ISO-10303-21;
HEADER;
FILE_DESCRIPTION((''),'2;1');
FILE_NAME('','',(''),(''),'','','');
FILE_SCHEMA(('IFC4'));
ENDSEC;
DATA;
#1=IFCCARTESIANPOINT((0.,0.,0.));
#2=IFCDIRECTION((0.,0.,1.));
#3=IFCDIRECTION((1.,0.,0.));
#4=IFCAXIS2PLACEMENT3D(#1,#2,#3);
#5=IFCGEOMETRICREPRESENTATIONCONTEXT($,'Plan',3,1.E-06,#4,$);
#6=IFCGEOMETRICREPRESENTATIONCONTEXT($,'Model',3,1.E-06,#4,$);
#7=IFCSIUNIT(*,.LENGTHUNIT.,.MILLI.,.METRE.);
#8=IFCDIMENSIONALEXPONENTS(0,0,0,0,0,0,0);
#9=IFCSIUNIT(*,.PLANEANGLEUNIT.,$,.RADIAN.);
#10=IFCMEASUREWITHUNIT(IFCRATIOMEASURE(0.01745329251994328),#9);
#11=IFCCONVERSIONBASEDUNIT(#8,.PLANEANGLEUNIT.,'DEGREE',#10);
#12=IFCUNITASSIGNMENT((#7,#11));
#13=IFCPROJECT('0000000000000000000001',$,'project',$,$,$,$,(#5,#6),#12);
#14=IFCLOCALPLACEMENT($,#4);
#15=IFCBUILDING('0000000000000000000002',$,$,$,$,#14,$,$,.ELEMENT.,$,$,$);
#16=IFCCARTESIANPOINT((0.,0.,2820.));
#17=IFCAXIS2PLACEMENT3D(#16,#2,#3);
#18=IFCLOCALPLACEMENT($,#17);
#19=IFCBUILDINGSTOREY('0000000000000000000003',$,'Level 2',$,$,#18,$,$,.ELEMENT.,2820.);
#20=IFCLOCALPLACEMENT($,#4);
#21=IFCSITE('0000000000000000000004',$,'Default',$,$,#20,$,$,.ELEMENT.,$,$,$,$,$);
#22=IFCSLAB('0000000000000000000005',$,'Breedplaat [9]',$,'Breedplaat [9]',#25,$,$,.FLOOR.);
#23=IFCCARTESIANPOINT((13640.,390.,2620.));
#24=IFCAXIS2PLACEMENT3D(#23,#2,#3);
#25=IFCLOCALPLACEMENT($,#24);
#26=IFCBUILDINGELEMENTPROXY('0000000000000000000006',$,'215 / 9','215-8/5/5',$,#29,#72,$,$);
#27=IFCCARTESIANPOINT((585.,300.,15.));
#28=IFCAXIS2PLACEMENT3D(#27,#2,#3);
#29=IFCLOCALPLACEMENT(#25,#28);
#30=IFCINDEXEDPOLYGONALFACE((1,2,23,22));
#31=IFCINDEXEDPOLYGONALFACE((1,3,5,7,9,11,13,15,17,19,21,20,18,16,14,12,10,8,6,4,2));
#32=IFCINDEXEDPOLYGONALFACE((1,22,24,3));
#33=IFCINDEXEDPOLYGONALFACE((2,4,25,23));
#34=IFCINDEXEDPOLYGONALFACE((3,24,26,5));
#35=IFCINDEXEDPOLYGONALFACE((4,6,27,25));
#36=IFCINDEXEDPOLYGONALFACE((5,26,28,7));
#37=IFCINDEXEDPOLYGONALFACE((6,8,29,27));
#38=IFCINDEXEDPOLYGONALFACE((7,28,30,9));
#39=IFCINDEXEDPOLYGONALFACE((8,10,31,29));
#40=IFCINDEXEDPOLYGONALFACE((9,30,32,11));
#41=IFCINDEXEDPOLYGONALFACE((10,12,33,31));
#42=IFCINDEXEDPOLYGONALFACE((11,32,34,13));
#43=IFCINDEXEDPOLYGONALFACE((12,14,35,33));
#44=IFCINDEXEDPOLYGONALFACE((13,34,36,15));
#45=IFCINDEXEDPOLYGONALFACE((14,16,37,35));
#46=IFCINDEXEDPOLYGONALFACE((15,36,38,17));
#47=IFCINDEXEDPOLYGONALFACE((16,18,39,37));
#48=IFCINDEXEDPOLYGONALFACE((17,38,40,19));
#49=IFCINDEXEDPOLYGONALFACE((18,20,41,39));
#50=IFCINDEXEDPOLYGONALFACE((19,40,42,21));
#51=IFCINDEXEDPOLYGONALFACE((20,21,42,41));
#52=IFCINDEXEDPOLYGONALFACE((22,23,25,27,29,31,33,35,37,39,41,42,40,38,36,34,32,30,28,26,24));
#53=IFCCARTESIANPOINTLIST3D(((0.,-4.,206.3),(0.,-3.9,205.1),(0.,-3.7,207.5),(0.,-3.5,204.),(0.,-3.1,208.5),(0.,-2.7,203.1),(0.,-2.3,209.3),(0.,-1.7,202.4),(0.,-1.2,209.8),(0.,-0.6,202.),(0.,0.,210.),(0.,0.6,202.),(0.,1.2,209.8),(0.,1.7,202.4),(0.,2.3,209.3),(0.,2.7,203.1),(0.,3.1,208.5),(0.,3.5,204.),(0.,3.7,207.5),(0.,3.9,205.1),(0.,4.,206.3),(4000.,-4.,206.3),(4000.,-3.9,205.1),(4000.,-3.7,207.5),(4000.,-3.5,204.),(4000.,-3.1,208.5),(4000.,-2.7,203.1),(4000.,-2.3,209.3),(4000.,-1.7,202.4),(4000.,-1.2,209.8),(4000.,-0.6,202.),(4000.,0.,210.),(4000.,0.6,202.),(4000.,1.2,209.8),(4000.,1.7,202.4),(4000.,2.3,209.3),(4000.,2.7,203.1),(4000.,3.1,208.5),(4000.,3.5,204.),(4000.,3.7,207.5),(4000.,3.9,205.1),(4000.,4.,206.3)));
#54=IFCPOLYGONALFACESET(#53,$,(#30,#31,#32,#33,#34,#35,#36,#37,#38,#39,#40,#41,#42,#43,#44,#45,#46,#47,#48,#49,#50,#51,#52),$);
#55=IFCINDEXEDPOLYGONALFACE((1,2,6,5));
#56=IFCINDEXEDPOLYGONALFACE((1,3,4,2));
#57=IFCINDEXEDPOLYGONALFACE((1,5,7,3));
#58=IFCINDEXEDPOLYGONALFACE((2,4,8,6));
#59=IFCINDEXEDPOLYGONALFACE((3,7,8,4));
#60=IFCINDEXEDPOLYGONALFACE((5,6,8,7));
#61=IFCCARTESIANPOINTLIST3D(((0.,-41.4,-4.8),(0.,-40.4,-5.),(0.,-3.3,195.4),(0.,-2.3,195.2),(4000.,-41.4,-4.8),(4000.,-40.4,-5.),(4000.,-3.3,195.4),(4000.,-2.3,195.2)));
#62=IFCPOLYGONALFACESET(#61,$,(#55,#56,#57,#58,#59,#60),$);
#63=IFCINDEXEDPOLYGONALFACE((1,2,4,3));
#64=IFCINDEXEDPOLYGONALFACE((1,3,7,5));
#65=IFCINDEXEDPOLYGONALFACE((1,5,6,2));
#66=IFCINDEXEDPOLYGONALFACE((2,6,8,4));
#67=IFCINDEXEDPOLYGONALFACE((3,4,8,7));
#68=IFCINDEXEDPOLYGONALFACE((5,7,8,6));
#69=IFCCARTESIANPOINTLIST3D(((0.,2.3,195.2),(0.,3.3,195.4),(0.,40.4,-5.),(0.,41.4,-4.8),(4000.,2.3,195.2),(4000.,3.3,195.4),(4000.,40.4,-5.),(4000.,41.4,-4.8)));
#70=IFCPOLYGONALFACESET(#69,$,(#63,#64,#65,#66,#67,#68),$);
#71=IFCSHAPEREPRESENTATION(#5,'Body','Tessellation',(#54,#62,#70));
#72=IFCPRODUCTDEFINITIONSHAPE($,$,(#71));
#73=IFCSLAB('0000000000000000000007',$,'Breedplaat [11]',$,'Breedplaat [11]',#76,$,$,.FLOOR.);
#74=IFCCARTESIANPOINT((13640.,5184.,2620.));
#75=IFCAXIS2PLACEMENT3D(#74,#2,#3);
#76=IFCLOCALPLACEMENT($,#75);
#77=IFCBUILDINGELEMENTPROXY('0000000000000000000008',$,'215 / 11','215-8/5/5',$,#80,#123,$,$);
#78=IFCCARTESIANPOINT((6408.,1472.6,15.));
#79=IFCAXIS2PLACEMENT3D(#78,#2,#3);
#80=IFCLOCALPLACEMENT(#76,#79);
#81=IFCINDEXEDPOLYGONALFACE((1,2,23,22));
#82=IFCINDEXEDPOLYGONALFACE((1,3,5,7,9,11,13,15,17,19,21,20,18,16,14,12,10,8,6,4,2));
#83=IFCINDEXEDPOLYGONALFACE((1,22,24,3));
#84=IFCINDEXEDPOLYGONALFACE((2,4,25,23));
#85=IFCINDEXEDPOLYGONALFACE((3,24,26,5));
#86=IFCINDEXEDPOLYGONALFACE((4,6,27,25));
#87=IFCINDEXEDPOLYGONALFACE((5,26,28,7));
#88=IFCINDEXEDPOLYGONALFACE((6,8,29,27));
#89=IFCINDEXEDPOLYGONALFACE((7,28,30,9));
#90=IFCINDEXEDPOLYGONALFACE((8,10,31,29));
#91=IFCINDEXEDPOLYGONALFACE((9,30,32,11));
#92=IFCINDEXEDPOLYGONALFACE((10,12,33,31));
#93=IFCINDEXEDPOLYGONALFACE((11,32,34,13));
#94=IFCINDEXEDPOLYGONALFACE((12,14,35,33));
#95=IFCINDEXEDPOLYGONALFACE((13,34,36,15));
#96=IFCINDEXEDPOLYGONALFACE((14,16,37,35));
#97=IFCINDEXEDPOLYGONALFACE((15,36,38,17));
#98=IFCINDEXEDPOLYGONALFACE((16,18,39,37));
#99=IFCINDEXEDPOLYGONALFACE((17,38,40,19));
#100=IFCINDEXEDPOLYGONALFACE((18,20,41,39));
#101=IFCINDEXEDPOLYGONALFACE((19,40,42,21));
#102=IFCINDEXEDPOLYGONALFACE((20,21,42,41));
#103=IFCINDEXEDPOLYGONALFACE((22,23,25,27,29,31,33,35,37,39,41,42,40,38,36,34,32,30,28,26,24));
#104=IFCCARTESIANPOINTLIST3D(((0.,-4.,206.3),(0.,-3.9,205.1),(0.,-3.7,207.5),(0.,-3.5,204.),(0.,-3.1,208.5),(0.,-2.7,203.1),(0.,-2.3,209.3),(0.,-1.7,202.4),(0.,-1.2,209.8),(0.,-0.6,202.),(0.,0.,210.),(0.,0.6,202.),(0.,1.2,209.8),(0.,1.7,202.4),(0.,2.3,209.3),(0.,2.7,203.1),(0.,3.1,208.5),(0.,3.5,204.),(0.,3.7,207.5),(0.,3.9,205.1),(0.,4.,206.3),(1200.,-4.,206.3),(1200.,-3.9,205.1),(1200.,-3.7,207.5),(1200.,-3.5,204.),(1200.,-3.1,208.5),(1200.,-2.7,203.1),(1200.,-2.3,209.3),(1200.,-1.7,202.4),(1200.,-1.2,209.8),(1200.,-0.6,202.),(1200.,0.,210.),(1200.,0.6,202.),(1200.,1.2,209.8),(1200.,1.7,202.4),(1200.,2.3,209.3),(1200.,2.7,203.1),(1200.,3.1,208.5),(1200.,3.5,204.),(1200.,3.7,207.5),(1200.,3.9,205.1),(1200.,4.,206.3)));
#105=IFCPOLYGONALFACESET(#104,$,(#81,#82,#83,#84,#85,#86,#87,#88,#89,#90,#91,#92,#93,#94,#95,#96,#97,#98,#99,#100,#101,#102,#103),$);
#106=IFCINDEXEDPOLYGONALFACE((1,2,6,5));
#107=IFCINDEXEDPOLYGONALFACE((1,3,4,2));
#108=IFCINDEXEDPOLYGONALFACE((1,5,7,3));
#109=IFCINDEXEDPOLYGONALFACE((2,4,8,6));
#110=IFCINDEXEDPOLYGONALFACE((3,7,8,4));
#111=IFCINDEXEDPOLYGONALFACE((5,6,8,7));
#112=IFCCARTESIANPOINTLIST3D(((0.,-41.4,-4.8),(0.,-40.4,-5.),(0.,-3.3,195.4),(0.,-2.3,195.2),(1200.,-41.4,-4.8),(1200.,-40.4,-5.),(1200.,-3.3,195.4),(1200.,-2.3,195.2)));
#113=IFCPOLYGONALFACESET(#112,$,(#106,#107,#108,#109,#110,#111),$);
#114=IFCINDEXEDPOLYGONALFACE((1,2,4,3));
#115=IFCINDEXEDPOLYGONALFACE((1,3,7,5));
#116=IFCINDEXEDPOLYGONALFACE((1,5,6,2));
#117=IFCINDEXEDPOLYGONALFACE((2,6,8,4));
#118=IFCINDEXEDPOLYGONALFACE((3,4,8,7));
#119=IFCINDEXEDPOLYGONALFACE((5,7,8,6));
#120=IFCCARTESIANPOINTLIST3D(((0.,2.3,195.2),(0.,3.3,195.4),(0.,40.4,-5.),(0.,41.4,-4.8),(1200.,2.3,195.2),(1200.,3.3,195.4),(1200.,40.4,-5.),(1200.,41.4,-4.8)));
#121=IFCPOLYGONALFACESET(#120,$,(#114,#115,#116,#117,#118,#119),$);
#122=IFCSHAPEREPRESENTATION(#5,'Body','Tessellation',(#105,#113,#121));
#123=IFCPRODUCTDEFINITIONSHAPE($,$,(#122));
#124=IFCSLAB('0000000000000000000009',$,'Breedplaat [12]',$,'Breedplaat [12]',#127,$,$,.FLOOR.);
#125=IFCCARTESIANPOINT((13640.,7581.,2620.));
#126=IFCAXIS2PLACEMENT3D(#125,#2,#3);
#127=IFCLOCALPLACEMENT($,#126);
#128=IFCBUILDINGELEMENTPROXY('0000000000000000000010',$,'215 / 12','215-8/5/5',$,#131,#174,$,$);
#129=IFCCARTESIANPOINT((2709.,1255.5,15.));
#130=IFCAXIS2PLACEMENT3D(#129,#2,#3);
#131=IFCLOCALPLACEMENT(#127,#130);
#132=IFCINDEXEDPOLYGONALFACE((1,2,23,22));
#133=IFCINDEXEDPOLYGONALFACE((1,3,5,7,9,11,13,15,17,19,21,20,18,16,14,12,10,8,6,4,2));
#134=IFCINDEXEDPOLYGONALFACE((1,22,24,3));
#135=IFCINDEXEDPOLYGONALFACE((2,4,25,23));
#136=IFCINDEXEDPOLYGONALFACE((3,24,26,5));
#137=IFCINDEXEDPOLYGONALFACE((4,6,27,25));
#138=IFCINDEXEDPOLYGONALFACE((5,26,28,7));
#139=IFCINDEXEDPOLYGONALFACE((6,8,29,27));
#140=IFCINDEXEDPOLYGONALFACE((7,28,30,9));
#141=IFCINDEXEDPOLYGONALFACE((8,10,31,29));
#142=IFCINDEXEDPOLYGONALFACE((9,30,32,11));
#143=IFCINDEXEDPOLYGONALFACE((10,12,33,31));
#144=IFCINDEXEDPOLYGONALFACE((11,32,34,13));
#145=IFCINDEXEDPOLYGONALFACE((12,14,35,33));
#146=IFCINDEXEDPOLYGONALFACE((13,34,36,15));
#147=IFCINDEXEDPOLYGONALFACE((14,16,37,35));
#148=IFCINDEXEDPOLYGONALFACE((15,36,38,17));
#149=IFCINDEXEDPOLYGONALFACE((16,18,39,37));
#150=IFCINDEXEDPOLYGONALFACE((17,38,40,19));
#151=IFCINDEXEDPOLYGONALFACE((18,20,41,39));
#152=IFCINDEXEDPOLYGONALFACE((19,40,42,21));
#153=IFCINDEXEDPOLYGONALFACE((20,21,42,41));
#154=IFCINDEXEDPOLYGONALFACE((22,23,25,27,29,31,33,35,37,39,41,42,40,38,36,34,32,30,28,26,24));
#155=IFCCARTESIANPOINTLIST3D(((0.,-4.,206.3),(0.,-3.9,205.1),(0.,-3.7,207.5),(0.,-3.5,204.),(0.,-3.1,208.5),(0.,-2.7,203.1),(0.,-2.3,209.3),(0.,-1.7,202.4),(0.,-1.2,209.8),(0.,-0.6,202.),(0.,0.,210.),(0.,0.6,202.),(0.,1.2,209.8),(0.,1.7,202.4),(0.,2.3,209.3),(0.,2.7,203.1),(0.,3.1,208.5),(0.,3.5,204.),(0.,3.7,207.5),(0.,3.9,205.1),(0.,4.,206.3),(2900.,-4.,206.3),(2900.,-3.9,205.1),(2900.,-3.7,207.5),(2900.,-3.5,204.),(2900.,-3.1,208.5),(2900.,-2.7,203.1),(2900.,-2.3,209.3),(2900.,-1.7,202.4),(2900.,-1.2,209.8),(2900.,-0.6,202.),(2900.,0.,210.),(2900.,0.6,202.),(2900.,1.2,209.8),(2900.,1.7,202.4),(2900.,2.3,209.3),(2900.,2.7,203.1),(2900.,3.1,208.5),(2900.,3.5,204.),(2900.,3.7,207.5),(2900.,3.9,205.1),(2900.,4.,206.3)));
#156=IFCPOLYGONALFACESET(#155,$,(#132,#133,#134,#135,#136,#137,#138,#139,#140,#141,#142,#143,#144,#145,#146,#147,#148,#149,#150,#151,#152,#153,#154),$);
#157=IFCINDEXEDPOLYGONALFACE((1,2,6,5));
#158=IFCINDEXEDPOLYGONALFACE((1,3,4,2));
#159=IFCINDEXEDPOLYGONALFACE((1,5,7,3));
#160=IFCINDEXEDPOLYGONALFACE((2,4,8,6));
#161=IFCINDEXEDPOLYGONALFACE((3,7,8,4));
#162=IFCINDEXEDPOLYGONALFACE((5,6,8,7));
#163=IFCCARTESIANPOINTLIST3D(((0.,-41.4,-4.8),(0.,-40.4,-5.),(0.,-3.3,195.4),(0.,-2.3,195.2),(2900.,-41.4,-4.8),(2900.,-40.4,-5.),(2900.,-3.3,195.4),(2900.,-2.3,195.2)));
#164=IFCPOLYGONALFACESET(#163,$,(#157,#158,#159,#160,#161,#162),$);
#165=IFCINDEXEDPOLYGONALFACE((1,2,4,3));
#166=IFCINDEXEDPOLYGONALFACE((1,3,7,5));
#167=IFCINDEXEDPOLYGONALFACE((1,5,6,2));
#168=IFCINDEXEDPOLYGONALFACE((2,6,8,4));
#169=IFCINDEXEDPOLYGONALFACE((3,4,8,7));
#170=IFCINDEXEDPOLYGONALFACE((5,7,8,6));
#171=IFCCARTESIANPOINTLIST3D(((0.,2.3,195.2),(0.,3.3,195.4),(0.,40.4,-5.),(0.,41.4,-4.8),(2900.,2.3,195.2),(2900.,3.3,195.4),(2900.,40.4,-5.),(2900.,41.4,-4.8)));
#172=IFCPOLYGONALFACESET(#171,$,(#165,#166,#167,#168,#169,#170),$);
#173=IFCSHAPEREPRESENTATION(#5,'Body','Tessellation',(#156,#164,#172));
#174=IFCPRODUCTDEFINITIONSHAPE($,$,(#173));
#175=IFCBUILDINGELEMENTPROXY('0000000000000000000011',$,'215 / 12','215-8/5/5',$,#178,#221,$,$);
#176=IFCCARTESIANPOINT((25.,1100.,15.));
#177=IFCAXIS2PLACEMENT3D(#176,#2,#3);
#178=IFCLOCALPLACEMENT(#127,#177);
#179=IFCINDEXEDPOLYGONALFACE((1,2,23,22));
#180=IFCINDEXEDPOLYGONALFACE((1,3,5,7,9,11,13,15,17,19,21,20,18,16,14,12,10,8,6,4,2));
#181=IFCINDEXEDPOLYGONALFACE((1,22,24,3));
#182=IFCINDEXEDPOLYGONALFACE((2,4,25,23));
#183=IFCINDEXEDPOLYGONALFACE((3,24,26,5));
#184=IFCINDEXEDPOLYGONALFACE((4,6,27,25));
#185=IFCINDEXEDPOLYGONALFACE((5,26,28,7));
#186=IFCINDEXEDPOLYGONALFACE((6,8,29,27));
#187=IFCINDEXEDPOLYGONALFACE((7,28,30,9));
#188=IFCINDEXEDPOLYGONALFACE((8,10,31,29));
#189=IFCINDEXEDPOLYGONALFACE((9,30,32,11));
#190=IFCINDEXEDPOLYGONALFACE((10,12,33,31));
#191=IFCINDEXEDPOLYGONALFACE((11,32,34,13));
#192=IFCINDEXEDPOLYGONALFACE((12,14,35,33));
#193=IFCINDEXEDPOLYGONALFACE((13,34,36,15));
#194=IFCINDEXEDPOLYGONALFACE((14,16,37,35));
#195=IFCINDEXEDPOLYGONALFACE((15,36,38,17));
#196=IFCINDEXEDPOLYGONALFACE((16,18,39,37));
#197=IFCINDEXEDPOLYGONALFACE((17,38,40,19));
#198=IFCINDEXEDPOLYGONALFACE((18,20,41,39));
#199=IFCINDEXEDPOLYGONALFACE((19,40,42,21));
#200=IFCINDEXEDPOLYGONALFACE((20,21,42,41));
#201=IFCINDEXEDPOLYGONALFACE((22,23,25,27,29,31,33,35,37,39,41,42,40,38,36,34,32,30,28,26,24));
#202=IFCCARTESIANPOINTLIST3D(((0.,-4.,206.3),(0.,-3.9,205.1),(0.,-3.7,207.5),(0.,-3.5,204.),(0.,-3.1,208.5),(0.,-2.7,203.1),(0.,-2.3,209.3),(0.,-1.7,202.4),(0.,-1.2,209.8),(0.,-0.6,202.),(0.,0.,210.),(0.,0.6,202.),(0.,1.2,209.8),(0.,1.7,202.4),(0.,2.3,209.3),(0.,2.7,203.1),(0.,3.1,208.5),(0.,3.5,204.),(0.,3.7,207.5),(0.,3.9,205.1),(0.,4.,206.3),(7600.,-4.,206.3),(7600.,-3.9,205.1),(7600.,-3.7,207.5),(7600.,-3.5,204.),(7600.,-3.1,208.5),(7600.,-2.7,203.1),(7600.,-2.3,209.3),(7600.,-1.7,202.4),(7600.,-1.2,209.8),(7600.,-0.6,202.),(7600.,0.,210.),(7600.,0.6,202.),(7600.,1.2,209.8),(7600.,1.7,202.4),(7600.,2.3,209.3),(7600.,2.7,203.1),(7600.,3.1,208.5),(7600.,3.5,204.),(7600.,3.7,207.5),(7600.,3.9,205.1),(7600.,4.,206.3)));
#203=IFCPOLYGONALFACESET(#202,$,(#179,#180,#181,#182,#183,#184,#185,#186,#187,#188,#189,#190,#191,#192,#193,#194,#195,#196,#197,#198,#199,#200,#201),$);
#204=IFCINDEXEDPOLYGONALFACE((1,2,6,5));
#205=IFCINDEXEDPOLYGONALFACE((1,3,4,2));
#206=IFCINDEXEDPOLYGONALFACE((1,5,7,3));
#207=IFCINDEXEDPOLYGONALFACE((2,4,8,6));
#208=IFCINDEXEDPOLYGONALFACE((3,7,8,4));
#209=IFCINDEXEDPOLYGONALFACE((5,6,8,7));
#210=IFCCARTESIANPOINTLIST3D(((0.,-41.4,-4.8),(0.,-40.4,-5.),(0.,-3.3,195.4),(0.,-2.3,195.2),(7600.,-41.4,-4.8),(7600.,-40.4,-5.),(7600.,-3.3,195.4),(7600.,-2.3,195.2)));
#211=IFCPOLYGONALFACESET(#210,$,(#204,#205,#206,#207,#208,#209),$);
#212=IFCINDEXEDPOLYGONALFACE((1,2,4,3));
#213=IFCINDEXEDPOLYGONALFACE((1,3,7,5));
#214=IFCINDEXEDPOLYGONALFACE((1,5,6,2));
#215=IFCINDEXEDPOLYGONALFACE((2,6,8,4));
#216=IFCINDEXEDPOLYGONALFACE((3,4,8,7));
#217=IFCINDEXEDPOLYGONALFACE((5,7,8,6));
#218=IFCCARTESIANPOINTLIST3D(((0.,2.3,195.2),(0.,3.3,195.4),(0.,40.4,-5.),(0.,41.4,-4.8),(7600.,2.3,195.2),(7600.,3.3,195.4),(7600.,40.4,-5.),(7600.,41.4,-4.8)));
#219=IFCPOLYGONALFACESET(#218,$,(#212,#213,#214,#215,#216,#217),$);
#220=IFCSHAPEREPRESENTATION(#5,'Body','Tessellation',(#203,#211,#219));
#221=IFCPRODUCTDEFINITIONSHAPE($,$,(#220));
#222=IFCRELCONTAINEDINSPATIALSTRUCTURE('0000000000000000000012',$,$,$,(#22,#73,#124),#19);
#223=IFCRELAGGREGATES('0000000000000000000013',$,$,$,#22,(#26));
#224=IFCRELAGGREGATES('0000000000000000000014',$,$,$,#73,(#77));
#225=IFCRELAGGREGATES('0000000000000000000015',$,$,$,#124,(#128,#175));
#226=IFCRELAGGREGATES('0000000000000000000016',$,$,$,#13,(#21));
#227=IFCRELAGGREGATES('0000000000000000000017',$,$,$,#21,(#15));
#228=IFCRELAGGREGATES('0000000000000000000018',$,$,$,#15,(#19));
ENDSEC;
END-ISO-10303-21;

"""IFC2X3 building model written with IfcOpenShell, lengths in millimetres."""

from ifc_helpers import new_model, entity, si_unit, converted_unit, frame, origin_with_axes, origin_2d_with_axis, place, context, project, spatial, rectangle, circle, extrude, element, aggregate, save


model = new_model("IFC2X3")

# Units and contexts
plan_context = context("Plan", 3, precision=1e-06, world=origin_with_axes())
model_context = context("Model", 3, precision=1e-06, world=origin_with_axes())
ifc_project = project(units=[si_unit("LENGTHUNIT", "METRE", prefix="MILLI"), converted_unit("PLANEANGLEUNIT", "DEGREE", entity("IfcRatioMeasure", 0.01745329251994328), si_unit("PLANEANGLEUNIT", "RADIAN"), dimensions=[0, 0, 0, 0, 0, 0, 0])], contexts=[plan_context, model_context])

# Site, building, storey
site_placement = place(None, origin_with_axes())
site = spatial("IfcSite", under=ifc_project, at=site_placement, Name="Default", CompositionType="ELEMENT")
building_placement = place(None, origin_with_axes())
building = spatial("IfcBuilding", under=site, at=building_placement, CompositionType="ELEMENT")
storey_placement = place(None, frame((0.0, 0.0, 2820.0), z_axis=(0.0, 0.0, 1.0), x_axis=(1.0, 0.0, 0.0)))
storey = spatial("IfcBuildingStorey", under=building, at=storey_placement, Name="Level 2", CompositionType="ELEMENT", Elevation=2820.0)

# Slabs, building element proxies
slab_1_placement = place(None, frame((13640.0, 390.0, 2620.0), z_axis=(0.0, 0.0, 1.0), x_axis=(1.0, 0.0, 0.0)))
slab_1 = element("IfcSlab", 1, at=slab_1_placement, inside=storey, Name="Breedplaat [9]", ObjectType="Breedplaat [9]", PredefinedType="FLOOR")
proxy_1_placement = place(slab_1_placement, frame((585.0, 300.0, 15.0), z_axis=(0.0, 0.0, 1.0), x_axis=(1.0, 0.0, 0.0)))
proxy_1 = element("IfcBuildingElementProxy", 2, at=proxy_1_placement, Name="215 / 9", Description="215-8/5/5", context=plan_context, shape_type="SweptSolid", body=[
    extrude(circle(Radius=4.0, at=origin_2d_with_axis()), frame((0.0, 0.0, 206.0), z_axis=(1.0, 0.0, 0.0), x_axis=(0.0, 0.0, 1.0)), (0.0, 0.0, 1.0), 4000.0),
    extrude(rectangle(XDim=203.8, YDim=1.0, at=origin_2d_with_axis()), frame((0.0, -21.9, 95.2), z_axis=(1.0, 0.0, 0.0), x_axis=(0.0, 0.187112, 0.982339)), (0.0, 0.0, 1.0), 4000.0),
    extrude(rectangle(XDim=203.8, YDim=1.0, at=origin_2d_with_axis()), frame((0.0, 21.9, 95.2), z_axis=(1.0, 0.0, 0.0), x_axis=(0.0, -0.187112, 0.982339)), (0.0, 0.0, 1.0), 4000.0),
])
aggregate(slab_1, [proxy_1])
slab_2_placement = place(None, frame((13640.0, 5184.0, 2620.0), z_axis=(0.0, 0.0, 1.0), x_axis=(1.0, 0.0, 0.0)))
slab_2 = element("IfcSlab", 3, at=slab_2_placement, inside=storey, Name="Breedplaat [11]", ObjectType="Breedplaat [11]", PredefinedType="FLOOR")
proxy_2_placement = place(slab_2_placement, frame((6408.0, 1472.6, 15.0), z_axis=(0.0, 0.0, 1.0), x_axis=(1.0, 0.0, 0.0)))
proxy_2 = element("IfcBuildingElementProxy", 4, at=proxy_2_placement, Name="215 / 11", Description="215-8/5/5", context=plan_context, shape_type="SweptSolid", body=[
    extrude(circle(Radius=4.0, at=origin_2d_with_axis()), frame((0.0, 0.0, 206.0), z_axis=(1.0, 0.0, 0.0), x_axis=(0.0, 0.0, 1.0)), (0.0, 0.0, 1.0), 1200.0),
    extrude(rectangle(XDim=203.8, YDim=1.0, at=origin_2d_with_axis()), frame((0.0, -21.9, 95.2), z_axis=(1.0, 0.0, 0.0), x_axis=(0.0, 0.187112, 0.982339)), (0.0, 0.0, 1.0), 1200.0),
    extrude(rectangle(XDim=203.8, YDim=1.0, at=origin_2d_with_axis()), frame((0.0, 21.9, 95.2), z_axis=(1.0, 0.0, 0.0), x_axis=(0.0, -0.187112, 0.982339)), (0.0, 0.0, 1.0), 1200.0),
])
aggregate(slab_2, [proxy_2])
slab_3_placement = place(None, frame((13640.0, 7581.0, 2620.0), z_axis=(0.0, 0.0, 1.0), x_axis=(1.0, 0.0, 0.0)))
slab_3 = element("IfcSlab", 5, at=slab_3_placement, inside=storey, Name="Breedplaat [12]", ObjectType="Breedplaat [12]", PredefinedType="FLOOR")
proxy_3_placement = place(slab_3_placement, frame((2709.0, 1255.5, 15.0), z_axis=(0.0, 0.0, 1.0), x_axis=(1.0, 0.0, 0.0)))
proxy_3 = element("IfcBuildingElementProxy", 6, at=proxy_3_placement, Name="215 / 12", Description="215-8/5/5", context=plan_context, shape_type="SweptSolid", body=[
    extrude(circle(Radius=4.0, at=origin_2d_with_axis()), frame((0.0, 0.0, 206.0), z_axis=(1.0, 0.0, 0.0), x_axis=(0.0, 0.0, 1.0)), (0.0, 0.0, 1.0), 2900.0),
    extrude(rectangle(XDim=203.8, YDim=1.0, at=origin_2d_with_axis()), frame((0.0, -21.9, 95.2), z_axis=(1.0, 0.0, 0.0), x_axis=(0.0, 0.187112, 0.982339)), (0.0, 0.0, 1.0), 2900.0),
    extrude(rectangle(XDim=203.8, YDim=1.0, at=origin_2d_with_axis()), frame((0.0, 21.9, 95.2), z_axis=(1.0, 0.0, 0.0), x_axis=(0.0, -0.187112, 0.982339)), (0.0, 0.0, 1.0), 2900.0),
])
proxy_4_placement = place(slab_3_placement, frame((25.0, 1100.0, 15.0), z_axis=(0.0, 0.0, 1.0), x_axis=(1.0, 0.0, 0.0)))
proxy_4 = element("IfcBuildingElementProxy", 7, at=proxy_4_placement, Name="215 / 12", Description="215-8/5/5", context=plan_context, shape_type="SweptSolid", body=[
    extrude(circle(Radius=4.0, at=origin_2d_with_axis()), frame((0.0, 0.0, 206.0), z_axis=(1.0, 0.0, 0.0), x_axis=(0.0, 0.0, 1.0)), (0.0, 0.0, 1.0), 7600.0),
    extrude(rectangle(XDim=203.8, YDim=1.0, at=origin_2d_with_axis()), frame((0.0, -21.9, 95.2), z_axis=(1.0, 0.0, 0.0), x_axis=(0.0, 0.187112, 0.982339)), (0.0, 0.0, 1.0), 7600.0),
    extrude(rectangle(XDim=203.8, YDim=1.0, at=origin_2d_with_axis()), frame((0.0, 21.9, 95.2), z_axis=(1.0, 0.0, 0.0), x_axis=(0.0, -0.187112, 0.982339)), (0.0, 0.0, 1.0), 7600.0),
])
aggregate(slab_3, [proxy_3, proxy_4])

save(model, "model.ifc")
